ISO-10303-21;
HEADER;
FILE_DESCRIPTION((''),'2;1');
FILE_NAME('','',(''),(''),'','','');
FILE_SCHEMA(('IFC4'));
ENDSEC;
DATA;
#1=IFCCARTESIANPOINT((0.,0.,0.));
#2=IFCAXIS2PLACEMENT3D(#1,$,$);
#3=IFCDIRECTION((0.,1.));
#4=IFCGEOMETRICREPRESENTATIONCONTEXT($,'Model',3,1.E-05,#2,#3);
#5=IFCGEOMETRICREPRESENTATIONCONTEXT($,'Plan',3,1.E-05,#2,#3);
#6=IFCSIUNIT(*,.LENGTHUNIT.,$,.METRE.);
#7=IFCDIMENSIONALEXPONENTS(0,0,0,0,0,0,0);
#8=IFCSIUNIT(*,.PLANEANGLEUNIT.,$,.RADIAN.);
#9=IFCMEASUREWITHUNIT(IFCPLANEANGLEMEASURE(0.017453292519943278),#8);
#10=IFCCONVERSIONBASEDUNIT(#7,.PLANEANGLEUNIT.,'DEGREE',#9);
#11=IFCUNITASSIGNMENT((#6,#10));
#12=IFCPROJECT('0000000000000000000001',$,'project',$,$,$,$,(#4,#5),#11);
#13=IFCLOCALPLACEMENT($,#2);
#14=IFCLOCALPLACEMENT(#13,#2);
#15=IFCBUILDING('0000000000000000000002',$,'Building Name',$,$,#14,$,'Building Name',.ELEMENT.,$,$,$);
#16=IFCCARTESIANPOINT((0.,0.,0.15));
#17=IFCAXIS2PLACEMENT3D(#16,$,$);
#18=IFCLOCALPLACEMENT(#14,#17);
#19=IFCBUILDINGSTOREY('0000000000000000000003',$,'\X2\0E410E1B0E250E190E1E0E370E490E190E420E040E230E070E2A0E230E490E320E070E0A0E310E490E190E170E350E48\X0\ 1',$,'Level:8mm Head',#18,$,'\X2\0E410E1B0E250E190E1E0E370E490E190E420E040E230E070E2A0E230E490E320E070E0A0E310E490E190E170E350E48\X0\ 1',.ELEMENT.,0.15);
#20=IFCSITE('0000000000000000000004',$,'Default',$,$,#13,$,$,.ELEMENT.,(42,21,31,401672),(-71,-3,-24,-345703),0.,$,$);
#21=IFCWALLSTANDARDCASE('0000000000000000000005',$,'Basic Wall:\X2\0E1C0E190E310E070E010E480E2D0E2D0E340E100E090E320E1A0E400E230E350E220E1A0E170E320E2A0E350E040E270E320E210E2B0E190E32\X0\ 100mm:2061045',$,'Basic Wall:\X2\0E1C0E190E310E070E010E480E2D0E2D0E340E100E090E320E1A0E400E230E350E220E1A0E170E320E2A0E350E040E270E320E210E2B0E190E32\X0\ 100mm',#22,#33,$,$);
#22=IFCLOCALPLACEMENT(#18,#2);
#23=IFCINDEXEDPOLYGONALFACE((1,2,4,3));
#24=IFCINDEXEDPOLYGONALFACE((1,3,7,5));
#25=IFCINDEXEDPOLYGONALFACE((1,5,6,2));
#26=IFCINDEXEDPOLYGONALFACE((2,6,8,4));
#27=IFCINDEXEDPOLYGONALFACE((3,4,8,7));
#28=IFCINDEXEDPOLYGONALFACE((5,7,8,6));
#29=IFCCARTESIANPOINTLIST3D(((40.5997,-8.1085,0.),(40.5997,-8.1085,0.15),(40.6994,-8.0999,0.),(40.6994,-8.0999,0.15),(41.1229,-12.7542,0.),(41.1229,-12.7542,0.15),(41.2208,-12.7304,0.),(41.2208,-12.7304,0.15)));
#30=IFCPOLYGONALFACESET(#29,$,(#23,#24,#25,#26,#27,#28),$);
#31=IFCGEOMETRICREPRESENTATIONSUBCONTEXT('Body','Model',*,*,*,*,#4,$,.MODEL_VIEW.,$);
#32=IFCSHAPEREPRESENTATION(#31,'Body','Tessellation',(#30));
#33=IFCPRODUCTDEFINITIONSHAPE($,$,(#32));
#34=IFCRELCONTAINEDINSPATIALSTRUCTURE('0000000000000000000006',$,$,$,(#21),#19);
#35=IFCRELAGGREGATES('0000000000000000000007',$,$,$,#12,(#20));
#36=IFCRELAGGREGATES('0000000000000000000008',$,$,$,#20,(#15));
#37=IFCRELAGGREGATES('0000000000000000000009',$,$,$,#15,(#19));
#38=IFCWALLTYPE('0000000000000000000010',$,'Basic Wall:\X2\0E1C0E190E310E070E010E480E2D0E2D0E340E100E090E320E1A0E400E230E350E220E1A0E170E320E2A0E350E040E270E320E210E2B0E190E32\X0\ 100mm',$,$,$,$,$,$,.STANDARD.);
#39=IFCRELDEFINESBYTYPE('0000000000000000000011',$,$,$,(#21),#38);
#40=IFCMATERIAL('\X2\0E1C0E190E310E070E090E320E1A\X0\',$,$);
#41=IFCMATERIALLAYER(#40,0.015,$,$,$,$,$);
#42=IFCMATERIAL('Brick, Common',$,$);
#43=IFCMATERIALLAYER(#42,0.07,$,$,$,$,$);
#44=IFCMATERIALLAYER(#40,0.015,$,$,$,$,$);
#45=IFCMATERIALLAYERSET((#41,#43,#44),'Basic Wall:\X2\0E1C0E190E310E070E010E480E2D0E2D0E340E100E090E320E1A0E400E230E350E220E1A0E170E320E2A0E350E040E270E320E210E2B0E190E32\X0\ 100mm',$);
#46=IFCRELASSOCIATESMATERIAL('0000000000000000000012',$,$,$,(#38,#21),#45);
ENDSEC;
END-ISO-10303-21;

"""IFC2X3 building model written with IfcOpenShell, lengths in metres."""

from ifc_helpers import new_model, entity, si_unit, converted_unit, direction, frame, origin, place, context, subcontext, project, spatial, polyline, outline, extrude, clip, halfspace, material, layer, layer_set, layer_usage, type_object, element, save


model = new_model("IFC2X3")

# Units and contexts
model_context = context("Model", 3, precision=1e-05, world=origin(), true_north=direction((0.0, 1.0)))
plan_context = context("Plan", 3, precision=1e-05, world=origin(), true_north=direction((0.0, 1.0)))
body_context = subcontext(model_context, "Body", "Model", "MODEL_VIEW")
ifc_project = project(units=[si_unit("LENGTHUNIT", "METRE"), converted_unit("PLANEANGLEUNIT", "DEGREE", entity("IfcPlaneAngleMeasure", 0.017453292519943278), si_unit("PLANEANGLEUNIT", "RADIAN"), dimensions=[0, 0, 0, 0, 0, 0, 0])], contexts=[model_context, plan_context])

# Site, building, storey
site_placement = place(None, origin())
site = spatial("IfcSite", under=ifc_project, at=site_placement, Name="Default", CompositionType="ELEMENT", RefLatitude=(42, 21, 31, 401672), RefLongitude=(-71, -3, -24, -345703), RefElevation=0.0)
building_placement = place(site_placement, origin())
building = spatial("IfcBuilding", under=site, at=building_placement, Name="Building Name", LongName="Building Name", CompositionType="ELEMENT")
storey_placement = place(building_placement, frame((0.0, 0.0, 0.15)))
storey = spatial("IfcBuildingStorey", under=building, at=storey_placement, Name="แปลนพื้นโครงสร้างชั้นที่ 1", ObjectType="Level:8mm Head", LongName="แปลนพื้นโครงสร้างชั้นที่ 1", CompositionType="ELEMENT", Elevation=0.15)

# Wall
ifc_material_1 = material(Name="ผนังฉาบ")
ifc_layer_1 = layer(ifc_material_1, 0.015)
ifc_material_2 = material(Name="Brick, Common")
ifc_layer_2 = layer(ifc_material_2, 0.07)
ifc_layer_3 = layer(ifc_material_1, 0.015)
ifc_layer_set_1 = layer_set([ifc_layer_1, ifc_layer_2, ifc_layer_3], Name="Basic Wall:ผนังก่ออิฐฉาบเรียบทาสีความหนา 100mm")
wall_type_1 = type_object("IfcWallType", Name="Basic Wall:ผนังก่ออิฐฉาบเรียบทาสีความหนา 100mm", PredefinedType="STANDARD", material=ifc_layer_set_1)
ifc_layer_usage_1 = layer_usage(ifc_layer_set_1, "AXIS2", "POSITIVE", -0.05)
wall_1_placement = place(storey_placement, frame((40.6494, -8.1029, 0.0), z_axis=(0.0, 0.0, 1.0), x_axis=(0.111904, -0.993719, 0.0)))
element("IfcWallStandardCase", 1, at=wall_1_placement, inside=storey, type_object=wall_type_1, material=ifc_layer_usage_1, Name="Basic Wall:ผนังก่ออิฐฉาบเรียบทาสีความหนา 100mm:2061045", ObjectType="Basic Wall:ผนังก่ออิฐฉาบเรียบทาสีความหนา 100mm", context=body_context, shape_type="Clipping", body=[
    clip(extrude(outline(polyline([(4.675, -0.05), (4.6623, 0.05), (2.4509, 0.05), (2.3509, 0.05), (0.0026, 0.05), (0.0, -0.05), (4.675, -0.05)])), origin(), (0.0, 0.0, 1.0), 0.15), halfspace(origin(), True)),
])

save(model, "model.ifc")
